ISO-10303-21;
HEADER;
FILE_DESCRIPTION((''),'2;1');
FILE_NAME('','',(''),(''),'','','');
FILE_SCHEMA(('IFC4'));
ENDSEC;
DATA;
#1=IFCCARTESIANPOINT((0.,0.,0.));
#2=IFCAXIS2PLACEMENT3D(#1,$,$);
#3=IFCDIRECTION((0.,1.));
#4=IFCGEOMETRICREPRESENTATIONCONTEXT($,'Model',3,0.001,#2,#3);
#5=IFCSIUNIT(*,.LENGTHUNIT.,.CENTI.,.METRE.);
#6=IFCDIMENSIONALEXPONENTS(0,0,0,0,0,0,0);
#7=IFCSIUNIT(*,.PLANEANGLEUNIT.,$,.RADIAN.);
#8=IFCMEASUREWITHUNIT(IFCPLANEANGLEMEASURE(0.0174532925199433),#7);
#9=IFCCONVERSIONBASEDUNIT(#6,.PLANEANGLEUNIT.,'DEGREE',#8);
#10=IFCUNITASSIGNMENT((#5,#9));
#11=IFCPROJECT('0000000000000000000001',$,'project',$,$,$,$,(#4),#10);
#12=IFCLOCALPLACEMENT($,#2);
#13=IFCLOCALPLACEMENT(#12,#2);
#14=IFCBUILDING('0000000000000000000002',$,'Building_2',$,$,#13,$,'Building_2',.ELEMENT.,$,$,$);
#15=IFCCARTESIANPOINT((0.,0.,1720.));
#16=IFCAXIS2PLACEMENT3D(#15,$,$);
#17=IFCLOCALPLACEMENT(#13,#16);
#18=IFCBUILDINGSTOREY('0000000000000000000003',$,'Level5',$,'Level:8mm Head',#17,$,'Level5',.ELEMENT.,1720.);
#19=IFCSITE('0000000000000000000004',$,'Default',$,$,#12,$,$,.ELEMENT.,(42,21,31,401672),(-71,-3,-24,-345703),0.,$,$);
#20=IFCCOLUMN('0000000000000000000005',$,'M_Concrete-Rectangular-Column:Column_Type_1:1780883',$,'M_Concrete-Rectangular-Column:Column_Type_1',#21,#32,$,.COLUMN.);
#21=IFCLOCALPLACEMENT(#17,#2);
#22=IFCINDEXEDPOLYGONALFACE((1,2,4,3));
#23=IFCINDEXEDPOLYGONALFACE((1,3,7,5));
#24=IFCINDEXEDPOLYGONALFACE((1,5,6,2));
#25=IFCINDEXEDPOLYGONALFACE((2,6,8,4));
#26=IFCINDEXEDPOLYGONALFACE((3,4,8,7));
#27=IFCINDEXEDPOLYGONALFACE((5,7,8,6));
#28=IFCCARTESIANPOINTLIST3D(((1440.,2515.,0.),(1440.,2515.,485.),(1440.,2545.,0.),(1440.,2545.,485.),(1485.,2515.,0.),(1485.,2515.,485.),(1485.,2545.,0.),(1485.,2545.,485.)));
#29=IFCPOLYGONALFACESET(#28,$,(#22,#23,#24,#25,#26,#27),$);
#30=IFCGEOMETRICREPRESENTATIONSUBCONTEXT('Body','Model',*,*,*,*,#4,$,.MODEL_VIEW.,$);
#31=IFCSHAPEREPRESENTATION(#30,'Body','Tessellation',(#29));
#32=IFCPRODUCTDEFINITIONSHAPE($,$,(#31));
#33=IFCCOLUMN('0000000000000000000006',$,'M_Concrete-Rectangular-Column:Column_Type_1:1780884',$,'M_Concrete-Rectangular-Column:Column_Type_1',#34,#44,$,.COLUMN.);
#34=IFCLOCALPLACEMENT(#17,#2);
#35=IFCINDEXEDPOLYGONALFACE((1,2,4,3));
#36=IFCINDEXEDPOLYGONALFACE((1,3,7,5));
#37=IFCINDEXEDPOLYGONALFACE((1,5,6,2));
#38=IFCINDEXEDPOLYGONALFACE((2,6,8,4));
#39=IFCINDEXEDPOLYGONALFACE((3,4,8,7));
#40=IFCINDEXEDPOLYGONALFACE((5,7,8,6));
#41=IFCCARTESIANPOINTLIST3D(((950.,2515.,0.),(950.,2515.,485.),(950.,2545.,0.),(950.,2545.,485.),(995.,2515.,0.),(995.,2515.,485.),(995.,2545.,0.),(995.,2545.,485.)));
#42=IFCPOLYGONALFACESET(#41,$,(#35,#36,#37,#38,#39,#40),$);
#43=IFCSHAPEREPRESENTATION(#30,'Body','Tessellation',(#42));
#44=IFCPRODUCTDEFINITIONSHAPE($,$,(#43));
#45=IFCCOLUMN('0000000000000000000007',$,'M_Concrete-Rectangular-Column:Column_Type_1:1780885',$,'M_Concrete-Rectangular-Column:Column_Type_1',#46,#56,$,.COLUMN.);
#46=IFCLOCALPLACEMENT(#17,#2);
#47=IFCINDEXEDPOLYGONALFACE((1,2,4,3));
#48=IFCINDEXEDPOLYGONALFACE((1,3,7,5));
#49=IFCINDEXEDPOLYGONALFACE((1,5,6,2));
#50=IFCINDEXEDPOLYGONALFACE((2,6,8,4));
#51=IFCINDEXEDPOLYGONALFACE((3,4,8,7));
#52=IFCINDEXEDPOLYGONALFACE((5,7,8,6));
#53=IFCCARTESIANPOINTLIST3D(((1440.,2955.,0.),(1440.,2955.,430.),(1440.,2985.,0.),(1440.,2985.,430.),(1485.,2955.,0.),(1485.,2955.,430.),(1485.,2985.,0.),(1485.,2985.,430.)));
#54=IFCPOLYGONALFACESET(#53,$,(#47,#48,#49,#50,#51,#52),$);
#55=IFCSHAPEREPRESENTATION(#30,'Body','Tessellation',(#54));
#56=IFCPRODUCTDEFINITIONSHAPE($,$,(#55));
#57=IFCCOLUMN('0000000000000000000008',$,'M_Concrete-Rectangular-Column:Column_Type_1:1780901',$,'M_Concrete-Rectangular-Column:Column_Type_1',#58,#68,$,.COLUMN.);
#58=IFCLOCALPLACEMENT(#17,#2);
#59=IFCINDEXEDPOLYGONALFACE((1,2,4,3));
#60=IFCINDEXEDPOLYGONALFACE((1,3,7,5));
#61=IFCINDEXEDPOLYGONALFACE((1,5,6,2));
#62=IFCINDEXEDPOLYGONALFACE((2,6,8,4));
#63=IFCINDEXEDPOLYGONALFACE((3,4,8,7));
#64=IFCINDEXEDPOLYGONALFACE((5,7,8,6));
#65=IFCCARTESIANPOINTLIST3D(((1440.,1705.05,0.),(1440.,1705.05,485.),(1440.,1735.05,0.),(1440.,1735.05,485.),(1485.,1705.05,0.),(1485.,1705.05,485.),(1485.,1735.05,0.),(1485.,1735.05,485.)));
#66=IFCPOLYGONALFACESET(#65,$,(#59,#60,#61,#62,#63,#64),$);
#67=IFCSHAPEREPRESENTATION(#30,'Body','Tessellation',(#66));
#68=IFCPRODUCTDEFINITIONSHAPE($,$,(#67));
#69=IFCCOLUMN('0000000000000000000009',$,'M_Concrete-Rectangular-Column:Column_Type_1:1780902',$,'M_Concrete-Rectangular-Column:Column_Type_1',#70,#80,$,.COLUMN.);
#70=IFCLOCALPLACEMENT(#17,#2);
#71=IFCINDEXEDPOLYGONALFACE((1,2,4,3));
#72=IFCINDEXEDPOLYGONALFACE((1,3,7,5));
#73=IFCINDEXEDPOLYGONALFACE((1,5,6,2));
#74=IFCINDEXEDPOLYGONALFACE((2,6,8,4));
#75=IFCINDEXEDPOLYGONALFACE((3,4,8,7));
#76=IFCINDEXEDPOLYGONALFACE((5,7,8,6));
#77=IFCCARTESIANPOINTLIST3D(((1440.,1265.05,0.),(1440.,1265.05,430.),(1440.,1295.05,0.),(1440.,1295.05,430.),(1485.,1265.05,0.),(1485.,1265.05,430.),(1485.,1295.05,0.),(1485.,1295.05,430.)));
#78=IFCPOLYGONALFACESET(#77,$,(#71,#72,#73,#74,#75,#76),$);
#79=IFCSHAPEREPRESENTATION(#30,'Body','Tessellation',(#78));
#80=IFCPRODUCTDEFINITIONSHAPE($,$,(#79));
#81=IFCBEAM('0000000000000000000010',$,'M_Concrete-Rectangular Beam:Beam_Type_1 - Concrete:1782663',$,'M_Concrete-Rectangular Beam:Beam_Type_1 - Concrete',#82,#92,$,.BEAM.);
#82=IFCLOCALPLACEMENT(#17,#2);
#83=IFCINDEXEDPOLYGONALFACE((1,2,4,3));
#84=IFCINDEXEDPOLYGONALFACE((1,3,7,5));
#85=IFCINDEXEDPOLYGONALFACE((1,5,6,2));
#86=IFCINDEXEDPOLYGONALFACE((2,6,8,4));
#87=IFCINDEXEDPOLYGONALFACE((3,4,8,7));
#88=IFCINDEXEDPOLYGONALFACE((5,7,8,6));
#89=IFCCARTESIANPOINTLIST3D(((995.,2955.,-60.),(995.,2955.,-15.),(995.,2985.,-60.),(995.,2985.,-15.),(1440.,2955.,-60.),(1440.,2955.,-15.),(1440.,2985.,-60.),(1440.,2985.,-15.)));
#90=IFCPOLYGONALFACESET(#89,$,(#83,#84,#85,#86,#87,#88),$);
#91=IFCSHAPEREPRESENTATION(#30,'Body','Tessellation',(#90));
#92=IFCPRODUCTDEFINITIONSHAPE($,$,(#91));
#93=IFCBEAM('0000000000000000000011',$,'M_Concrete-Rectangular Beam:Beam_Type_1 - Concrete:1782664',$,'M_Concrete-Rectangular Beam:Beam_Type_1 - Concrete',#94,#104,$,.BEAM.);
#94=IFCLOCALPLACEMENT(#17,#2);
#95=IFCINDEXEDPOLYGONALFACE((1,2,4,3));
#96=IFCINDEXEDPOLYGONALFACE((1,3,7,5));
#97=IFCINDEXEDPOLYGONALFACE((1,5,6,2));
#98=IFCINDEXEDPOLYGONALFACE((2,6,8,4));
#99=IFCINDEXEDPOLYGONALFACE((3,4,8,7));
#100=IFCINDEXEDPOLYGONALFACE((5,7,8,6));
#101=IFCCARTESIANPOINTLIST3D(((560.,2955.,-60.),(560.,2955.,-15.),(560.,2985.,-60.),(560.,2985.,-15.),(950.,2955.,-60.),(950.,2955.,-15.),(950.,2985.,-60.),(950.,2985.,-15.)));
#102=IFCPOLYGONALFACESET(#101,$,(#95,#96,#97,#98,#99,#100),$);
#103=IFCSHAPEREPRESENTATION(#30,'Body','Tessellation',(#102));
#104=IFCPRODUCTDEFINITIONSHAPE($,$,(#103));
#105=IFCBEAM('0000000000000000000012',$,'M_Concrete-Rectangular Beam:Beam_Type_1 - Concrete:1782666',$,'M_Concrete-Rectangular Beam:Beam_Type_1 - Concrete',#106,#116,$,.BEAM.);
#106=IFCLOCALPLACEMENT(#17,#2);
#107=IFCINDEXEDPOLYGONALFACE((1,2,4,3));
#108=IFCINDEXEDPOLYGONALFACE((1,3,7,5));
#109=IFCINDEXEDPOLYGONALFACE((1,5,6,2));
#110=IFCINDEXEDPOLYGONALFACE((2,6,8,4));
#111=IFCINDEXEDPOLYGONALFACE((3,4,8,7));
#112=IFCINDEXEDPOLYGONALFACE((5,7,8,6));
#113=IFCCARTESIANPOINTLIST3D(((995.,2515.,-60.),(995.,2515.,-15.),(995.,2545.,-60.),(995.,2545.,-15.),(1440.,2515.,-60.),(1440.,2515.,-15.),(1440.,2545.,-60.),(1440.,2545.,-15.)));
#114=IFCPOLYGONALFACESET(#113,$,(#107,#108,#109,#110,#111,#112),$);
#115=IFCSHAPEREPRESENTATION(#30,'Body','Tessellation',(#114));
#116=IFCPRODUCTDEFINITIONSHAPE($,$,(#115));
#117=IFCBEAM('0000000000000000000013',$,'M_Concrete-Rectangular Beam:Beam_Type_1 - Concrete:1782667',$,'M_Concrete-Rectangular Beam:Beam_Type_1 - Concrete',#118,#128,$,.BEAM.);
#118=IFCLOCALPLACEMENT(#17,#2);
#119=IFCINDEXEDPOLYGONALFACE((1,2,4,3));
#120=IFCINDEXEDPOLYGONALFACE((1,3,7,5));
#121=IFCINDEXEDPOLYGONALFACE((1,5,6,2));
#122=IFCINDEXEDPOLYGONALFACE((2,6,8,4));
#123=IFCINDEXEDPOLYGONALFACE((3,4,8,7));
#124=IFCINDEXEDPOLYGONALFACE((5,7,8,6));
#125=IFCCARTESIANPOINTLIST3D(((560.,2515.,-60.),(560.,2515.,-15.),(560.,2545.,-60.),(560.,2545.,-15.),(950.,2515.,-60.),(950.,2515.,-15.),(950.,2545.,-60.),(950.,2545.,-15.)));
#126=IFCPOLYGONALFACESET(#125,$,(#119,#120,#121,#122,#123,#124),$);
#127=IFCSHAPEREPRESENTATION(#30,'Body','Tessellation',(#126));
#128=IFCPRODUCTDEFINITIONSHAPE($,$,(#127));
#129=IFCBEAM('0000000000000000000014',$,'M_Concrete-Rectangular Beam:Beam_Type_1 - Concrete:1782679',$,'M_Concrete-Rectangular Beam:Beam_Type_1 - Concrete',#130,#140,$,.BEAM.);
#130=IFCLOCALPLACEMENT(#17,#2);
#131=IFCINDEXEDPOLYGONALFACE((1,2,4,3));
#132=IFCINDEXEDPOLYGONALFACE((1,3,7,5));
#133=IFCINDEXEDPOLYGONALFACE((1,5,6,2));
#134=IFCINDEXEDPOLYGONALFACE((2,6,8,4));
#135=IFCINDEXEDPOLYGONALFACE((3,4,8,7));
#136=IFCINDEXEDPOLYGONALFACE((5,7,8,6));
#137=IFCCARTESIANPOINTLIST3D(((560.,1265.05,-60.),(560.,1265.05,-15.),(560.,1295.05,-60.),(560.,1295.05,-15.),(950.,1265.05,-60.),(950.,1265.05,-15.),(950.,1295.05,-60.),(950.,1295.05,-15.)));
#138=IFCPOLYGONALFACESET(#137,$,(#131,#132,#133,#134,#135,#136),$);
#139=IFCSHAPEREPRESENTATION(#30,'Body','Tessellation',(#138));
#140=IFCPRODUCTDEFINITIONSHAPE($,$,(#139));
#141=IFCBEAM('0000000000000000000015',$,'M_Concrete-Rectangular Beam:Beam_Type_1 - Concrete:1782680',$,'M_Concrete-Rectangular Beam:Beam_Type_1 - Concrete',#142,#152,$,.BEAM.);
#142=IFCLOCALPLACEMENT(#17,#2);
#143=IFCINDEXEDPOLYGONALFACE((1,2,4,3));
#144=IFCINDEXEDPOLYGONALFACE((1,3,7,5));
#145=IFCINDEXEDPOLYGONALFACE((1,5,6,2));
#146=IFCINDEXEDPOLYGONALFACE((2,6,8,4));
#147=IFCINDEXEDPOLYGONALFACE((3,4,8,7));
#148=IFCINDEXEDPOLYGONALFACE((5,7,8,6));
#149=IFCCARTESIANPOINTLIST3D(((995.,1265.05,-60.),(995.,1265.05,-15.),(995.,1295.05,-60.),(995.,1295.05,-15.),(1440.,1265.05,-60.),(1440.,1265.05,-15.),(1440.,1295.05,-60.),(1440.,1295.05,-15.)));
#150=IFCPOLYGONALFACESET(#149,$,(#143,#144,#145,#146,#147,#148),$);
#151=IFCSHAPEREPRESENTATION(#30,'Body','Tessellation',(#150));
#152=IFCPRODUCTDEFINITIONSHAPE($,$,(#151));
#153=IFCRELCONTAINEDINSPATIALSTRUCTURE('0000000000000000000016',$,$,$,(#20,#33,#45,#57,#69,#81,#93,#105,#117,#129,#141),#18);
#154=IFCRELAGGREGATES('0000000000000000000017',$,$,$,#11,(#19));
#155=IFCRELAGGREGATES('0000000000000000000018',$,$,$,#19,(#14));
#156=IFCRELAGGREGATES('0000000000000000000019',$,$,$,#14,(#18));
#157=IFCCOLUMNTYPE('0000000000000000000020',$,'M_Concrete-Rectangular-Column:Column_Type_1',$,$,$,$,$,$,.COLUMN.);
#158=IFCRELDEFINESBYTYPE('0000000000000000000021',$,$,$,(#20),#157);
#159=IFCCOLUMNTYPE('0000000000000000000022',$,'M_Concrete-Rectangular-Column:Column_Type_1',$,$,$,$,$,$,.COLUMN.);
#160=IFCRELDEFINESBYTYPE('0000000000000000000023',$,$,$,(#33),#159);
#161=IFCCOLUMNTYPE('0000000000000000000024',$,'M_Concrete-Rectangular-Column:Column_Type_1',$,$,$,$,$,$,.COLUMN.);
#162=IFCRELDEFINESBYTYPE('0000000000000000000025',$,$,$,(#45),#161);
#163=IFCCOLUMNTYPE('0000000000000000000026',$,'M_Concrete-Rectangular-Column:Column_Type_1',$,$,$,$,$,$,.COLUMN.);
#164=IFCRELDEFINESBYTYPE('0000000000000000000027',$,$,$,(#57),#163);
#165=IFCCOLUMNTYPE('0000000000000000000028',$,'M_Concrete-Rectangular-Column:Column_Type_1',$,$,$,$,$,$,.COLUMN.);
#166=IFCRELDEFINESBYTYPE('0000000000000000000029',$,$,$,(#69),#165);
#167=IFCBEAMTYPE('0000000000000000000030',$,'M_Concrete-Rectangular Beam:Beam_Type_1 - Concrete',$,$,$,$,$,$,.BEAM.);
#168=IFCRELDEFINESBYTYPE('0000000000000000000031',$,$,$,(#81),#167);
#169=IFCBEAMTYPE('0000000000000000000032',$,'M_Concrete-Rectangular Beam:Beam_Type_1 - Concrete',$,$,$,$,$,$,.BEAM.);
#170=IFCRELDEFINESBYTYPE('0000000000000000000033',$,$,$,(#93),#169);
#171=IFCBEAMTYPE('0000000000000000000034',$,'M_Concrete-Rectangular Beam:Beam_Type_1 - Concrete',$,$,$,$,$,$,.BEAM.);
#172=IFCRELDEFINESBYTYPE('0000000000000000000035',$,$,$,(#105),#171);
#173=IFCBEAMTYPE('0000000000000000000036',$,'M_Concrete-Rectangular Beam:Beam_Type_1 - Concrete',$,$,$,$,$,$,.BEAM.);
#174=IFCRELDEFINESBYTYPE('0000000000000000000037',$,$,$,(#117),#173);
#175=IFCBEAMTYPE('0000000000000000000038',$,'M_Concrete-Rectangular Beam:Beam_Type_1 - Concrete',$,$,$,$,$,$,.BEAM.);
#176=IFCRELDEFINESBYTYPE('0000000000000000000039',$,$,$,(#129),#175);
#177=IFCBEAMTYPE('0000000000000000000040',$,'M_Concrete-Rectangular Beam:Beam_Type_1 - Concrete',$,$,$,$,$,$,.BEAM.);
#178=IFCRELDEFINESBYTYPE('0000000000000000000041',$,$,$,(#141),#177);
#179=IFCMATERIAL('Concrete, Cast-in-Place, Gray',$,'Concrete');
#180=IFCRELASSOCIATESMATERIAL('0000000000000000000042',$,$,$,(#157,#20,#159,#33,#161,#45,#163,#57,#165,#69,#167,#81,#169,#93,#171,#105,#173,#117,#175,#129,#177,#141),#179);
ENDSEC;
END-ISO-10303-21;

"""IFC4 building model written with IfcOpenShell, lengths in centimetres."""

from ifc_helpers import new_model, entity, si_unit, converted_unit, direction, frame, origin, place, context, subcontext, project, spatial, indexed_curve, outline, extrude, source, transform, mapped, material, type_object, type_shapes, element, save


model = new_model("IFC4")

# Units and contexts
model_context = context("Model", 3, precision=0.001, world=origin(), true_north=direction((0.0, 1.0)))
body_context = subcontext(model_context, "Body", "Model", "MODEL_VIEW")
ifc_project = project(units=[si_unit("LENGTHUNIT", "METRE", prefix="CENTI"), converted_unit("PLANEANGLEUNIT", "DEGREE", entity("IfcPlaneAngleMeasure", 0.0174532925199433), si_unit("PLANEANGLEUNIT", "RADIAN"), dimensions=[0, 0, 0, 0, 0, 0, 0])], contexts=[model_context])

# Site, building, storey
site_placement = place(None, origin())
site = spatial("IfcSite", under=ifc_project, at=site_placement, Name="Default", CompositionType="ELEMENT", RefLatitude=(42, 21, 31, 401672), RefLongitude=(-71, -3, -24, -345703), RefElevation=0.0)
building_placement = place(site_placement, origin())
building = spatial("IfcBuilding", under=site, at=building_placement, Name="Building_2", LongName="Building_2", CompositionType="ELEMENT")
storey_placement = place(building_placement, frame((0.0, 0.0, 1720.0)))
storey = spatial("IfcBuildingStorey", under=building, at=storey_placement, Name="Level5", ObjectType="Level:8mm Head", LongName="Level5", CompositionType="ELEMENT", Elevation=1720.0)

# Columns
ifc_material = material(Name="Concrete, Cast-in-Place, Gray", Category="Concrete")
column_type_1 = type_object("IfcColumnType", Name="M_Concrete-Rectangular-Column:Column_Type_1", PredefinedType="COLUMN", material=ifc_material)
shared_shape_1 = source(origin(), body_context, "Body", "SweptSolid", [
    extrude(outline(indexed_curve([(-15.0, -22.5), (15.0, -22.5), (15.0, 22.5), (-15.0, 22.5), (-15.0, -22.5)], self_intersect=False)), frame((1462.5, 2530.0, 1720.0), z_axis=(0.0, 0.0, 1.0), x_axis=(0.0, -1.0, 0.0)), (0.0, 0.0, 1.0), 485.0),
])
type_shapes(column_type_1, [shared_shape_1])
column_1_placement = place(storey_placement, frame((0.0, 0.0, -1720.0)))
element("IfcColumn", 1, at=column_1_placement, inside=storey, type_object=column_type_1, material=ifc_material, Name="M_Concrete-Rectangular-Column:Column_Type_1:1780883", ObjectType="M_Concrete-Rectangular-Column:Column_Type_1", PredefinedType="COLUMN", context=body_context, shape_type="MappedRepresentation", body=[
    mapped(shared_shape_1, transform((0.0, 0.0, 0.0), scale=1.0)),
])
column_type_2 = type_object("IfcColumnType", Name="M_Concrete-Rectangular-Column:Column_Type_1", PredefinedType="COLUMN", material=ifc_material)
shared_shape_2 = source(origin(), body_context, "Body", "SweptSolid", [
    extrude(outline(indexed_curve([(-15.0, -22.5), (15.0, -22.5), (15.0, 22.5), (-15.0, 22.5), (-15.0, -22.5)], self_intersect=False)), frame((972.5, 2530.0, 1720.0), z_axis=(0.0, 0.0, 1.0), x_axis=(0.0, -1.0, 0.0)), (0.0, 0.0, 1.0), 485.0),
])
type_shapes(column_type_2, [shared_shape_2])
column_2_placement = place(storey_placement, frame((0.0, 0.0, -1720.0)))
element("IfcColumn", 2, at=column_2_placement, inside=storey, type_object=column_type_2, material=ifc_material, Name="M_Concrete-Rectangular-Column:Column_Type_1:1780884", ObjectType="M_Concrete-Rectangular-Column:Column_Type_1", PredefinedType="COLUMN", context=body_context, shape_type="MappedRepresentation", body=[
    mapped(shared_shape_2, transform((0.0, 0.0, 0.0), scale=1.0)),
])
column_type_3 = type_object("IfcColumnType", Name="M_Concrete-Rectangular-Column:Column_Type_1", PredefinedType="COLUMN", material=ifc_material)
shared_shape_3 = source(origin(), body_context, "Body", "SweptSolid", [
    extrude(outline(indexed_curve([(-22.5, -15.0), (22.5, -15.0), (22.5, 15.0), (-22.5, 15.0), (-22.5, -15.0)], self_intersect=False)), frame((1462.5, 2970.0, 1720.0)), (0.0, 0.0, 1.0), 430.0),
])
type_shapes(column_type_3, [shared_shape_3])
column_3_placement = place(storey_placement, frame((0.0, 0.0, -1720.0)))
element("IfcColumn", 3, at=column_3_placement, inside=storey, type_object=column_type_3, material=ifc_material, Name="M_Concrete-Rectangular-Column:Column_Type_1:1780885", ObjectType="M_Concrete-Rectangular-Column:Column_Type_1", PredefinedType="COLUMN", context=body_context, shape_type="MappedRepresentation", body=[
    mapped(shared_shape_3, transform((0.0, 0.0, 0.0), scale=1.0)),
])
column_type_4 = type_object("IfcColumnType", Name="M_Concrete-Rectangular-Column:Column_Type_1", PredefinedType="COLUMN", material=ifc_material)
shared_shape_4 = source(origin(), body_context, "Body", "SweptSolid", [
    extrude(outline(indexed_curve([(-22.5, -15.0), (22.5, -15.0), (22.5, 15.0), (-22.5, 15.0), (-22.5, -15.0)], self_intersect=False)), frame((1462.5, 1720.05, 1720.0)), (0.0, 0.0, 1.0), 485.0),
])
type_shapes(column_type_4, [shared_shape_4])
column_4_placement = place(storey_placement, frame((0.0, 0.0, -1720.0)))
element("IfcColumn", 4, at=column_4_placement, inside=storey, type_object=column_type_4, material=ifc_material, Name="M_Concrete-Rectangular-Column:Column_Type_1:1780901", ObjectType="M_Concrete-Rectangular-Column:Column_Type_1", PredefinedType="COLUMN", context=body_context, shape_type="MappedRepresentation", body=[
    mapped(shared_shape_4, transform((0.0, 0.0, 0.0), scale=1.0)),
])
column_type_5 = type_object("IfcColumnType", Name="M_Concrete-Rectangular-Column:Column_Type_1", PredefinedType="COLUMN", material=ifc_material)
shared_shape_5 = source(origin(), body_context, "Body", "SweptSolid", [
    extrude(outline(indexed_curve([(-15.0, -22.5), (15.0, -22.5), (15.0, 22.5), (-15.0, 22.5), (-15.0, -22.5)], self_intersect=False)), frame((1462.5, 1280.05, 1720.0), z_axis=(0.0, 0.0, 1.0), x_axis=(0.0, -1.0, 0.0)), (0.0, 0.0, 1.0), 430.0),
])
type_shapes(column_type_5, [shared_shape_5])
column_5_placement = place(storey_placement, frame((0.0, 0.0, -1720.0)))
element("IfcColumn", 5, at=column_5_placement, inside=storey, type_object=column_type_5, material=ifc_material, Name="M_Concrete-Rectangular-Column:Column_Type_1:1780902", ObjectType="M_Concrete-Rectangular-Column:Column_Type_1", PredefinedType="COLUMN", context=body_context, shape_type="MappedRepresentation", body=[
    mapped(shared_shape_5, transform((0.0, 0.0, 0.0), scale=1.0)),
])

# Beams
beam_type_1 = type_object("IfcBeamType", Name="M_Concrete-Rectangular Beam:Beam_Type_1 - Concrete", PredefinedType="BEAM", material=ifc_material)
shared_shape_6 = source(origin(), body_context, "Body", "SweptSolid", [
    extrude(outline(indexed_curve([(-22.5, -15.0), (22.5, -15.0), (22.5, 15.0), (-22.5, 15.0), (-22.5, -15.0)], self_intersect=False)), frame((995.0, 2970.0, 1682.5), z_axis=(1.0, 0.0, 0.0), x_axis=(0.0, 0.0, -1.0)), (0.0, 0.0, 1.0), 445.0),
])
type_shapes(beam_type_1, [shared_shape_6])
beam_1_placement = place(storey_placement, frame((0.0, 0.0, -1720.0)))
element("IfcBeam", 6, at=beam_1_placement, inside=storey, type_object=beam_type_1, material=ifc_material, Name="M_Concrete-Rectangular Beam:Beam_Type_1 - Concrete:1782663", ObjectType="M_Concrete-Rectangular Beam:Beam_Type_1 - Concrete", PredefinedType="BEAM", context=body_context, shape_type="MappedRepresentation", body=[
    mapped(shared_shape_6, transform((0.0, 0.0, 0.0), scale=1.0)),
])
beam_type_2 = type_object("IfcBeamType", Name="M_Concrete-Rectangular Beam:Beam_Type_1 - Concrete", PredefinedType="BEAM", material=ifc_material)
shared_shape_7 = source(origin(), body_context, "Body", "SweptSolid", [
    extrude(outline(indexed_curve([(-22.5, -15.0), (22.5, -15.0), (22.5, 15.0), (-22.5, 15.0), (-22.5, -15.0)], self_intersect=False)), frame((560.0, 2970.0, 1682.5), z_axis=(1.0, 0.0, 0.0), x_axis=(0.0, 0.0, -1.0)), (0.0, 0.0, 1.0), 390.0),
])
type_shapes(beam_type_2, [shared_shape_7])
beam_2_placement = place(storey_placement, frame((0.0, 0.0, -1720.0)))
element("IfcBeam", 7, at=beam_2_placement, inside=storey, type_object=beam_type_2, material=ifc_material, Name="M_Concrete-Rectangular Beam:Beam_Type_1 - Concrete:1782664", ObjectType="M_Concrete-Rectangular Beam:Beam_Type_1 - Concrete", PredefinedType="BEAM", context=body_context, shape_type="MappedRepresentation", body=[
    mapped(shared_shape_7, transform((0.0, 0.0, 0.0), scale=1.0)),
])
beam_type_3 = type_object("IfcBeamType", Name="M_Concrete-Rectangular Beam:Beam_Type_1 - Concrete", PredefinedType="BEAM", material=ifc_material)
shared_shape_8 = source(origin(), body_context, "Body", "SweptSolid", [
    extrude(outline(indexed_curve([(-22.5, -15.0), (22.5, -15.0), (22.5, 15.0), (-22.5, 15.0), (-22.5, -15.0)], self_intersect=False)), frame((995.0, 2530.0, 1682.5), z_axis=(1.0, 0.0, 0.0), x_axis=(0.0, 0.0, -1.0)), (0.0, 0.0, 1.0), 445.0),
])
type_shapes(beam_type_3, [shared_shape_8])
beam_3_placement = place(storey_placement, frame((0.0, 0.0, -1720.0)))
element("IfcBeam", 8, at=beam_3_placement, inside=storey, type_object=beam_type_3, material=ifc_material, Name="M_Concrete-Rectangular Beam:Beam_Type_1 - Concrete:1782666", ObjectType="M_Concrete-Rectangular Beam:Beam_Type_1 - Concrete", PredefinedType="BEAM", context=body_context, shape_type="MappedRepresentation", body=[
    mapped(shared_shape_8, transform((0.0, 0.0, 0.0), scale=1.0)),
])
beam_type_4 = type_object("IfcBeamType", Name="M_Concrete-Rectangular Beam:Beam_Type_1 - Concrete", PredefinedType="BEAM", material=ifc_material)
shared_shape_9 = source(origin(), body_context, "Body", "SweptSolid", [
    extrude(outline(indexed_curve([(-22.5, -15.0), (22.5, -15.0), (22.5, 15.0), (-22.5, 15.0), (-22.5, -15.0)], self_intersect=False)), frame((560.0, 2530.0, 1682.5), z_axis=(1.0, 0.0, 0.0), x_axis=(0.0, 0.0, -1.0)), (0.0, 0.0, 1.0), 390.0),
])
type_shapes(beam_type_4, [shared_shape_9])
beam_4_placement = place(storey_placement, frame((0.0, 0.0, -1720.0)))
element("IfcBeam", 9, at=beam_4_placement, inside=storey, type_object=beam_type_4, material=ifc_material, Name="M_Concrete-Rectangular Beam:Beam_Type_1 - Concrete:1782667", ObjectType="M_Concrete-Rectangular Beam:Beam_Type_1 - Concrete", PredefinedType="BEAM", context=body_context, shape_type="MappedRepresentation", body=[
    mapped(shared_shape_9, transform((0.0, 0.0, 0.0), scale=1.0)),
])
beam_type_5 = type_object("IfcBeamType", Name="M_Concrete-Rectangular Beam:Beam_Type_1 - Concrete", PredefinedType="BEAM", material=ifc_material)
shared_shape_10 = source(origin(), body_context, "Body", "SweptSolid", [
    extrude(outline(indexed_curve([(-22.5, -15.0), (22.5, -15.0), (22.5, 15.0), (-22.5, 15.0), (-22.5, -15.0)], self_intersect=False)), frame((560.0, 1280.05, 1682.5), z_axis=(1.0, 0.0, 0.0), x_axis=(0.0, 0.0, -1.0)), (0.0, 0.0, 1.0), 390.0),
])
type_shapes(beam_type_5, [shared_shape_10])
beam_5_placement = place(storey_placement, frame((0.0, 0.0, -1720.0)))
element("IfcBeam", 10, at=beam_5_placement, inside=storey, type_object=beam_type_5, material=ifc_material, Name="M_Concrete-Rectangular Beam:Beam_Type_1 - Concrete:1782679", ObjectType="M_Concrete-Rectangular Beam:Beam_Type_1 - Concrete", PredefinedType="BEAM", context=body_context, shape_type="MappedRepresentation", body=[
    mapped(shared_shape_10, transform((0.0, 0.0, 0.0), scale=1.0)),
])
beam_type_6 = type_object("IfcBeamType", Name="M_Concrete-Rectangular Beam:Beam_Type_1 - Concrete", PredefinedType="BEAM", material=ifc_material)
shared_shape_11 = source(origin(), body_context, "Body", "SweptSolid", [
    extrude(outline(indexed_curve([(-22.5, -15.0), (22.5, -15.0), (22.5, 15.0), (-22.5, 15.0), (-22.5, -15.0)], self_intersect=False)), frame((995.0, 1280.05, 1682.5), z_axis=(1.0, 0.0, 0.0), x_axis=(0.0, 0.0, -1.0)), (0.0, 0.0, 1.0), 445.0),
])
type_shapes(beam_type_6, [shared_shape_11])
beam_6_placement = place(storey_placement, frame((0.0, 0.0, -1720.0)))
element("IfcBeam", 11, at=beam_6_placement, inside=storey, type_object=beam_type_6, material=ifc_material, Name="M_Concrete-Rectangular Beam:Beam_Type_1 - Concrete:1782680", ObjectType="M_Concrete-Rectangular Beam:Beam_Type_1 - Concrete", PredefinedType="BEAM", context=body_context, shape_type="MappedRepresentation", body=[
    mapped(shared_shape_11, transform((0.0, 0.0, 0.0), scale=1.0)),
])

save(model, "model.ifc")
